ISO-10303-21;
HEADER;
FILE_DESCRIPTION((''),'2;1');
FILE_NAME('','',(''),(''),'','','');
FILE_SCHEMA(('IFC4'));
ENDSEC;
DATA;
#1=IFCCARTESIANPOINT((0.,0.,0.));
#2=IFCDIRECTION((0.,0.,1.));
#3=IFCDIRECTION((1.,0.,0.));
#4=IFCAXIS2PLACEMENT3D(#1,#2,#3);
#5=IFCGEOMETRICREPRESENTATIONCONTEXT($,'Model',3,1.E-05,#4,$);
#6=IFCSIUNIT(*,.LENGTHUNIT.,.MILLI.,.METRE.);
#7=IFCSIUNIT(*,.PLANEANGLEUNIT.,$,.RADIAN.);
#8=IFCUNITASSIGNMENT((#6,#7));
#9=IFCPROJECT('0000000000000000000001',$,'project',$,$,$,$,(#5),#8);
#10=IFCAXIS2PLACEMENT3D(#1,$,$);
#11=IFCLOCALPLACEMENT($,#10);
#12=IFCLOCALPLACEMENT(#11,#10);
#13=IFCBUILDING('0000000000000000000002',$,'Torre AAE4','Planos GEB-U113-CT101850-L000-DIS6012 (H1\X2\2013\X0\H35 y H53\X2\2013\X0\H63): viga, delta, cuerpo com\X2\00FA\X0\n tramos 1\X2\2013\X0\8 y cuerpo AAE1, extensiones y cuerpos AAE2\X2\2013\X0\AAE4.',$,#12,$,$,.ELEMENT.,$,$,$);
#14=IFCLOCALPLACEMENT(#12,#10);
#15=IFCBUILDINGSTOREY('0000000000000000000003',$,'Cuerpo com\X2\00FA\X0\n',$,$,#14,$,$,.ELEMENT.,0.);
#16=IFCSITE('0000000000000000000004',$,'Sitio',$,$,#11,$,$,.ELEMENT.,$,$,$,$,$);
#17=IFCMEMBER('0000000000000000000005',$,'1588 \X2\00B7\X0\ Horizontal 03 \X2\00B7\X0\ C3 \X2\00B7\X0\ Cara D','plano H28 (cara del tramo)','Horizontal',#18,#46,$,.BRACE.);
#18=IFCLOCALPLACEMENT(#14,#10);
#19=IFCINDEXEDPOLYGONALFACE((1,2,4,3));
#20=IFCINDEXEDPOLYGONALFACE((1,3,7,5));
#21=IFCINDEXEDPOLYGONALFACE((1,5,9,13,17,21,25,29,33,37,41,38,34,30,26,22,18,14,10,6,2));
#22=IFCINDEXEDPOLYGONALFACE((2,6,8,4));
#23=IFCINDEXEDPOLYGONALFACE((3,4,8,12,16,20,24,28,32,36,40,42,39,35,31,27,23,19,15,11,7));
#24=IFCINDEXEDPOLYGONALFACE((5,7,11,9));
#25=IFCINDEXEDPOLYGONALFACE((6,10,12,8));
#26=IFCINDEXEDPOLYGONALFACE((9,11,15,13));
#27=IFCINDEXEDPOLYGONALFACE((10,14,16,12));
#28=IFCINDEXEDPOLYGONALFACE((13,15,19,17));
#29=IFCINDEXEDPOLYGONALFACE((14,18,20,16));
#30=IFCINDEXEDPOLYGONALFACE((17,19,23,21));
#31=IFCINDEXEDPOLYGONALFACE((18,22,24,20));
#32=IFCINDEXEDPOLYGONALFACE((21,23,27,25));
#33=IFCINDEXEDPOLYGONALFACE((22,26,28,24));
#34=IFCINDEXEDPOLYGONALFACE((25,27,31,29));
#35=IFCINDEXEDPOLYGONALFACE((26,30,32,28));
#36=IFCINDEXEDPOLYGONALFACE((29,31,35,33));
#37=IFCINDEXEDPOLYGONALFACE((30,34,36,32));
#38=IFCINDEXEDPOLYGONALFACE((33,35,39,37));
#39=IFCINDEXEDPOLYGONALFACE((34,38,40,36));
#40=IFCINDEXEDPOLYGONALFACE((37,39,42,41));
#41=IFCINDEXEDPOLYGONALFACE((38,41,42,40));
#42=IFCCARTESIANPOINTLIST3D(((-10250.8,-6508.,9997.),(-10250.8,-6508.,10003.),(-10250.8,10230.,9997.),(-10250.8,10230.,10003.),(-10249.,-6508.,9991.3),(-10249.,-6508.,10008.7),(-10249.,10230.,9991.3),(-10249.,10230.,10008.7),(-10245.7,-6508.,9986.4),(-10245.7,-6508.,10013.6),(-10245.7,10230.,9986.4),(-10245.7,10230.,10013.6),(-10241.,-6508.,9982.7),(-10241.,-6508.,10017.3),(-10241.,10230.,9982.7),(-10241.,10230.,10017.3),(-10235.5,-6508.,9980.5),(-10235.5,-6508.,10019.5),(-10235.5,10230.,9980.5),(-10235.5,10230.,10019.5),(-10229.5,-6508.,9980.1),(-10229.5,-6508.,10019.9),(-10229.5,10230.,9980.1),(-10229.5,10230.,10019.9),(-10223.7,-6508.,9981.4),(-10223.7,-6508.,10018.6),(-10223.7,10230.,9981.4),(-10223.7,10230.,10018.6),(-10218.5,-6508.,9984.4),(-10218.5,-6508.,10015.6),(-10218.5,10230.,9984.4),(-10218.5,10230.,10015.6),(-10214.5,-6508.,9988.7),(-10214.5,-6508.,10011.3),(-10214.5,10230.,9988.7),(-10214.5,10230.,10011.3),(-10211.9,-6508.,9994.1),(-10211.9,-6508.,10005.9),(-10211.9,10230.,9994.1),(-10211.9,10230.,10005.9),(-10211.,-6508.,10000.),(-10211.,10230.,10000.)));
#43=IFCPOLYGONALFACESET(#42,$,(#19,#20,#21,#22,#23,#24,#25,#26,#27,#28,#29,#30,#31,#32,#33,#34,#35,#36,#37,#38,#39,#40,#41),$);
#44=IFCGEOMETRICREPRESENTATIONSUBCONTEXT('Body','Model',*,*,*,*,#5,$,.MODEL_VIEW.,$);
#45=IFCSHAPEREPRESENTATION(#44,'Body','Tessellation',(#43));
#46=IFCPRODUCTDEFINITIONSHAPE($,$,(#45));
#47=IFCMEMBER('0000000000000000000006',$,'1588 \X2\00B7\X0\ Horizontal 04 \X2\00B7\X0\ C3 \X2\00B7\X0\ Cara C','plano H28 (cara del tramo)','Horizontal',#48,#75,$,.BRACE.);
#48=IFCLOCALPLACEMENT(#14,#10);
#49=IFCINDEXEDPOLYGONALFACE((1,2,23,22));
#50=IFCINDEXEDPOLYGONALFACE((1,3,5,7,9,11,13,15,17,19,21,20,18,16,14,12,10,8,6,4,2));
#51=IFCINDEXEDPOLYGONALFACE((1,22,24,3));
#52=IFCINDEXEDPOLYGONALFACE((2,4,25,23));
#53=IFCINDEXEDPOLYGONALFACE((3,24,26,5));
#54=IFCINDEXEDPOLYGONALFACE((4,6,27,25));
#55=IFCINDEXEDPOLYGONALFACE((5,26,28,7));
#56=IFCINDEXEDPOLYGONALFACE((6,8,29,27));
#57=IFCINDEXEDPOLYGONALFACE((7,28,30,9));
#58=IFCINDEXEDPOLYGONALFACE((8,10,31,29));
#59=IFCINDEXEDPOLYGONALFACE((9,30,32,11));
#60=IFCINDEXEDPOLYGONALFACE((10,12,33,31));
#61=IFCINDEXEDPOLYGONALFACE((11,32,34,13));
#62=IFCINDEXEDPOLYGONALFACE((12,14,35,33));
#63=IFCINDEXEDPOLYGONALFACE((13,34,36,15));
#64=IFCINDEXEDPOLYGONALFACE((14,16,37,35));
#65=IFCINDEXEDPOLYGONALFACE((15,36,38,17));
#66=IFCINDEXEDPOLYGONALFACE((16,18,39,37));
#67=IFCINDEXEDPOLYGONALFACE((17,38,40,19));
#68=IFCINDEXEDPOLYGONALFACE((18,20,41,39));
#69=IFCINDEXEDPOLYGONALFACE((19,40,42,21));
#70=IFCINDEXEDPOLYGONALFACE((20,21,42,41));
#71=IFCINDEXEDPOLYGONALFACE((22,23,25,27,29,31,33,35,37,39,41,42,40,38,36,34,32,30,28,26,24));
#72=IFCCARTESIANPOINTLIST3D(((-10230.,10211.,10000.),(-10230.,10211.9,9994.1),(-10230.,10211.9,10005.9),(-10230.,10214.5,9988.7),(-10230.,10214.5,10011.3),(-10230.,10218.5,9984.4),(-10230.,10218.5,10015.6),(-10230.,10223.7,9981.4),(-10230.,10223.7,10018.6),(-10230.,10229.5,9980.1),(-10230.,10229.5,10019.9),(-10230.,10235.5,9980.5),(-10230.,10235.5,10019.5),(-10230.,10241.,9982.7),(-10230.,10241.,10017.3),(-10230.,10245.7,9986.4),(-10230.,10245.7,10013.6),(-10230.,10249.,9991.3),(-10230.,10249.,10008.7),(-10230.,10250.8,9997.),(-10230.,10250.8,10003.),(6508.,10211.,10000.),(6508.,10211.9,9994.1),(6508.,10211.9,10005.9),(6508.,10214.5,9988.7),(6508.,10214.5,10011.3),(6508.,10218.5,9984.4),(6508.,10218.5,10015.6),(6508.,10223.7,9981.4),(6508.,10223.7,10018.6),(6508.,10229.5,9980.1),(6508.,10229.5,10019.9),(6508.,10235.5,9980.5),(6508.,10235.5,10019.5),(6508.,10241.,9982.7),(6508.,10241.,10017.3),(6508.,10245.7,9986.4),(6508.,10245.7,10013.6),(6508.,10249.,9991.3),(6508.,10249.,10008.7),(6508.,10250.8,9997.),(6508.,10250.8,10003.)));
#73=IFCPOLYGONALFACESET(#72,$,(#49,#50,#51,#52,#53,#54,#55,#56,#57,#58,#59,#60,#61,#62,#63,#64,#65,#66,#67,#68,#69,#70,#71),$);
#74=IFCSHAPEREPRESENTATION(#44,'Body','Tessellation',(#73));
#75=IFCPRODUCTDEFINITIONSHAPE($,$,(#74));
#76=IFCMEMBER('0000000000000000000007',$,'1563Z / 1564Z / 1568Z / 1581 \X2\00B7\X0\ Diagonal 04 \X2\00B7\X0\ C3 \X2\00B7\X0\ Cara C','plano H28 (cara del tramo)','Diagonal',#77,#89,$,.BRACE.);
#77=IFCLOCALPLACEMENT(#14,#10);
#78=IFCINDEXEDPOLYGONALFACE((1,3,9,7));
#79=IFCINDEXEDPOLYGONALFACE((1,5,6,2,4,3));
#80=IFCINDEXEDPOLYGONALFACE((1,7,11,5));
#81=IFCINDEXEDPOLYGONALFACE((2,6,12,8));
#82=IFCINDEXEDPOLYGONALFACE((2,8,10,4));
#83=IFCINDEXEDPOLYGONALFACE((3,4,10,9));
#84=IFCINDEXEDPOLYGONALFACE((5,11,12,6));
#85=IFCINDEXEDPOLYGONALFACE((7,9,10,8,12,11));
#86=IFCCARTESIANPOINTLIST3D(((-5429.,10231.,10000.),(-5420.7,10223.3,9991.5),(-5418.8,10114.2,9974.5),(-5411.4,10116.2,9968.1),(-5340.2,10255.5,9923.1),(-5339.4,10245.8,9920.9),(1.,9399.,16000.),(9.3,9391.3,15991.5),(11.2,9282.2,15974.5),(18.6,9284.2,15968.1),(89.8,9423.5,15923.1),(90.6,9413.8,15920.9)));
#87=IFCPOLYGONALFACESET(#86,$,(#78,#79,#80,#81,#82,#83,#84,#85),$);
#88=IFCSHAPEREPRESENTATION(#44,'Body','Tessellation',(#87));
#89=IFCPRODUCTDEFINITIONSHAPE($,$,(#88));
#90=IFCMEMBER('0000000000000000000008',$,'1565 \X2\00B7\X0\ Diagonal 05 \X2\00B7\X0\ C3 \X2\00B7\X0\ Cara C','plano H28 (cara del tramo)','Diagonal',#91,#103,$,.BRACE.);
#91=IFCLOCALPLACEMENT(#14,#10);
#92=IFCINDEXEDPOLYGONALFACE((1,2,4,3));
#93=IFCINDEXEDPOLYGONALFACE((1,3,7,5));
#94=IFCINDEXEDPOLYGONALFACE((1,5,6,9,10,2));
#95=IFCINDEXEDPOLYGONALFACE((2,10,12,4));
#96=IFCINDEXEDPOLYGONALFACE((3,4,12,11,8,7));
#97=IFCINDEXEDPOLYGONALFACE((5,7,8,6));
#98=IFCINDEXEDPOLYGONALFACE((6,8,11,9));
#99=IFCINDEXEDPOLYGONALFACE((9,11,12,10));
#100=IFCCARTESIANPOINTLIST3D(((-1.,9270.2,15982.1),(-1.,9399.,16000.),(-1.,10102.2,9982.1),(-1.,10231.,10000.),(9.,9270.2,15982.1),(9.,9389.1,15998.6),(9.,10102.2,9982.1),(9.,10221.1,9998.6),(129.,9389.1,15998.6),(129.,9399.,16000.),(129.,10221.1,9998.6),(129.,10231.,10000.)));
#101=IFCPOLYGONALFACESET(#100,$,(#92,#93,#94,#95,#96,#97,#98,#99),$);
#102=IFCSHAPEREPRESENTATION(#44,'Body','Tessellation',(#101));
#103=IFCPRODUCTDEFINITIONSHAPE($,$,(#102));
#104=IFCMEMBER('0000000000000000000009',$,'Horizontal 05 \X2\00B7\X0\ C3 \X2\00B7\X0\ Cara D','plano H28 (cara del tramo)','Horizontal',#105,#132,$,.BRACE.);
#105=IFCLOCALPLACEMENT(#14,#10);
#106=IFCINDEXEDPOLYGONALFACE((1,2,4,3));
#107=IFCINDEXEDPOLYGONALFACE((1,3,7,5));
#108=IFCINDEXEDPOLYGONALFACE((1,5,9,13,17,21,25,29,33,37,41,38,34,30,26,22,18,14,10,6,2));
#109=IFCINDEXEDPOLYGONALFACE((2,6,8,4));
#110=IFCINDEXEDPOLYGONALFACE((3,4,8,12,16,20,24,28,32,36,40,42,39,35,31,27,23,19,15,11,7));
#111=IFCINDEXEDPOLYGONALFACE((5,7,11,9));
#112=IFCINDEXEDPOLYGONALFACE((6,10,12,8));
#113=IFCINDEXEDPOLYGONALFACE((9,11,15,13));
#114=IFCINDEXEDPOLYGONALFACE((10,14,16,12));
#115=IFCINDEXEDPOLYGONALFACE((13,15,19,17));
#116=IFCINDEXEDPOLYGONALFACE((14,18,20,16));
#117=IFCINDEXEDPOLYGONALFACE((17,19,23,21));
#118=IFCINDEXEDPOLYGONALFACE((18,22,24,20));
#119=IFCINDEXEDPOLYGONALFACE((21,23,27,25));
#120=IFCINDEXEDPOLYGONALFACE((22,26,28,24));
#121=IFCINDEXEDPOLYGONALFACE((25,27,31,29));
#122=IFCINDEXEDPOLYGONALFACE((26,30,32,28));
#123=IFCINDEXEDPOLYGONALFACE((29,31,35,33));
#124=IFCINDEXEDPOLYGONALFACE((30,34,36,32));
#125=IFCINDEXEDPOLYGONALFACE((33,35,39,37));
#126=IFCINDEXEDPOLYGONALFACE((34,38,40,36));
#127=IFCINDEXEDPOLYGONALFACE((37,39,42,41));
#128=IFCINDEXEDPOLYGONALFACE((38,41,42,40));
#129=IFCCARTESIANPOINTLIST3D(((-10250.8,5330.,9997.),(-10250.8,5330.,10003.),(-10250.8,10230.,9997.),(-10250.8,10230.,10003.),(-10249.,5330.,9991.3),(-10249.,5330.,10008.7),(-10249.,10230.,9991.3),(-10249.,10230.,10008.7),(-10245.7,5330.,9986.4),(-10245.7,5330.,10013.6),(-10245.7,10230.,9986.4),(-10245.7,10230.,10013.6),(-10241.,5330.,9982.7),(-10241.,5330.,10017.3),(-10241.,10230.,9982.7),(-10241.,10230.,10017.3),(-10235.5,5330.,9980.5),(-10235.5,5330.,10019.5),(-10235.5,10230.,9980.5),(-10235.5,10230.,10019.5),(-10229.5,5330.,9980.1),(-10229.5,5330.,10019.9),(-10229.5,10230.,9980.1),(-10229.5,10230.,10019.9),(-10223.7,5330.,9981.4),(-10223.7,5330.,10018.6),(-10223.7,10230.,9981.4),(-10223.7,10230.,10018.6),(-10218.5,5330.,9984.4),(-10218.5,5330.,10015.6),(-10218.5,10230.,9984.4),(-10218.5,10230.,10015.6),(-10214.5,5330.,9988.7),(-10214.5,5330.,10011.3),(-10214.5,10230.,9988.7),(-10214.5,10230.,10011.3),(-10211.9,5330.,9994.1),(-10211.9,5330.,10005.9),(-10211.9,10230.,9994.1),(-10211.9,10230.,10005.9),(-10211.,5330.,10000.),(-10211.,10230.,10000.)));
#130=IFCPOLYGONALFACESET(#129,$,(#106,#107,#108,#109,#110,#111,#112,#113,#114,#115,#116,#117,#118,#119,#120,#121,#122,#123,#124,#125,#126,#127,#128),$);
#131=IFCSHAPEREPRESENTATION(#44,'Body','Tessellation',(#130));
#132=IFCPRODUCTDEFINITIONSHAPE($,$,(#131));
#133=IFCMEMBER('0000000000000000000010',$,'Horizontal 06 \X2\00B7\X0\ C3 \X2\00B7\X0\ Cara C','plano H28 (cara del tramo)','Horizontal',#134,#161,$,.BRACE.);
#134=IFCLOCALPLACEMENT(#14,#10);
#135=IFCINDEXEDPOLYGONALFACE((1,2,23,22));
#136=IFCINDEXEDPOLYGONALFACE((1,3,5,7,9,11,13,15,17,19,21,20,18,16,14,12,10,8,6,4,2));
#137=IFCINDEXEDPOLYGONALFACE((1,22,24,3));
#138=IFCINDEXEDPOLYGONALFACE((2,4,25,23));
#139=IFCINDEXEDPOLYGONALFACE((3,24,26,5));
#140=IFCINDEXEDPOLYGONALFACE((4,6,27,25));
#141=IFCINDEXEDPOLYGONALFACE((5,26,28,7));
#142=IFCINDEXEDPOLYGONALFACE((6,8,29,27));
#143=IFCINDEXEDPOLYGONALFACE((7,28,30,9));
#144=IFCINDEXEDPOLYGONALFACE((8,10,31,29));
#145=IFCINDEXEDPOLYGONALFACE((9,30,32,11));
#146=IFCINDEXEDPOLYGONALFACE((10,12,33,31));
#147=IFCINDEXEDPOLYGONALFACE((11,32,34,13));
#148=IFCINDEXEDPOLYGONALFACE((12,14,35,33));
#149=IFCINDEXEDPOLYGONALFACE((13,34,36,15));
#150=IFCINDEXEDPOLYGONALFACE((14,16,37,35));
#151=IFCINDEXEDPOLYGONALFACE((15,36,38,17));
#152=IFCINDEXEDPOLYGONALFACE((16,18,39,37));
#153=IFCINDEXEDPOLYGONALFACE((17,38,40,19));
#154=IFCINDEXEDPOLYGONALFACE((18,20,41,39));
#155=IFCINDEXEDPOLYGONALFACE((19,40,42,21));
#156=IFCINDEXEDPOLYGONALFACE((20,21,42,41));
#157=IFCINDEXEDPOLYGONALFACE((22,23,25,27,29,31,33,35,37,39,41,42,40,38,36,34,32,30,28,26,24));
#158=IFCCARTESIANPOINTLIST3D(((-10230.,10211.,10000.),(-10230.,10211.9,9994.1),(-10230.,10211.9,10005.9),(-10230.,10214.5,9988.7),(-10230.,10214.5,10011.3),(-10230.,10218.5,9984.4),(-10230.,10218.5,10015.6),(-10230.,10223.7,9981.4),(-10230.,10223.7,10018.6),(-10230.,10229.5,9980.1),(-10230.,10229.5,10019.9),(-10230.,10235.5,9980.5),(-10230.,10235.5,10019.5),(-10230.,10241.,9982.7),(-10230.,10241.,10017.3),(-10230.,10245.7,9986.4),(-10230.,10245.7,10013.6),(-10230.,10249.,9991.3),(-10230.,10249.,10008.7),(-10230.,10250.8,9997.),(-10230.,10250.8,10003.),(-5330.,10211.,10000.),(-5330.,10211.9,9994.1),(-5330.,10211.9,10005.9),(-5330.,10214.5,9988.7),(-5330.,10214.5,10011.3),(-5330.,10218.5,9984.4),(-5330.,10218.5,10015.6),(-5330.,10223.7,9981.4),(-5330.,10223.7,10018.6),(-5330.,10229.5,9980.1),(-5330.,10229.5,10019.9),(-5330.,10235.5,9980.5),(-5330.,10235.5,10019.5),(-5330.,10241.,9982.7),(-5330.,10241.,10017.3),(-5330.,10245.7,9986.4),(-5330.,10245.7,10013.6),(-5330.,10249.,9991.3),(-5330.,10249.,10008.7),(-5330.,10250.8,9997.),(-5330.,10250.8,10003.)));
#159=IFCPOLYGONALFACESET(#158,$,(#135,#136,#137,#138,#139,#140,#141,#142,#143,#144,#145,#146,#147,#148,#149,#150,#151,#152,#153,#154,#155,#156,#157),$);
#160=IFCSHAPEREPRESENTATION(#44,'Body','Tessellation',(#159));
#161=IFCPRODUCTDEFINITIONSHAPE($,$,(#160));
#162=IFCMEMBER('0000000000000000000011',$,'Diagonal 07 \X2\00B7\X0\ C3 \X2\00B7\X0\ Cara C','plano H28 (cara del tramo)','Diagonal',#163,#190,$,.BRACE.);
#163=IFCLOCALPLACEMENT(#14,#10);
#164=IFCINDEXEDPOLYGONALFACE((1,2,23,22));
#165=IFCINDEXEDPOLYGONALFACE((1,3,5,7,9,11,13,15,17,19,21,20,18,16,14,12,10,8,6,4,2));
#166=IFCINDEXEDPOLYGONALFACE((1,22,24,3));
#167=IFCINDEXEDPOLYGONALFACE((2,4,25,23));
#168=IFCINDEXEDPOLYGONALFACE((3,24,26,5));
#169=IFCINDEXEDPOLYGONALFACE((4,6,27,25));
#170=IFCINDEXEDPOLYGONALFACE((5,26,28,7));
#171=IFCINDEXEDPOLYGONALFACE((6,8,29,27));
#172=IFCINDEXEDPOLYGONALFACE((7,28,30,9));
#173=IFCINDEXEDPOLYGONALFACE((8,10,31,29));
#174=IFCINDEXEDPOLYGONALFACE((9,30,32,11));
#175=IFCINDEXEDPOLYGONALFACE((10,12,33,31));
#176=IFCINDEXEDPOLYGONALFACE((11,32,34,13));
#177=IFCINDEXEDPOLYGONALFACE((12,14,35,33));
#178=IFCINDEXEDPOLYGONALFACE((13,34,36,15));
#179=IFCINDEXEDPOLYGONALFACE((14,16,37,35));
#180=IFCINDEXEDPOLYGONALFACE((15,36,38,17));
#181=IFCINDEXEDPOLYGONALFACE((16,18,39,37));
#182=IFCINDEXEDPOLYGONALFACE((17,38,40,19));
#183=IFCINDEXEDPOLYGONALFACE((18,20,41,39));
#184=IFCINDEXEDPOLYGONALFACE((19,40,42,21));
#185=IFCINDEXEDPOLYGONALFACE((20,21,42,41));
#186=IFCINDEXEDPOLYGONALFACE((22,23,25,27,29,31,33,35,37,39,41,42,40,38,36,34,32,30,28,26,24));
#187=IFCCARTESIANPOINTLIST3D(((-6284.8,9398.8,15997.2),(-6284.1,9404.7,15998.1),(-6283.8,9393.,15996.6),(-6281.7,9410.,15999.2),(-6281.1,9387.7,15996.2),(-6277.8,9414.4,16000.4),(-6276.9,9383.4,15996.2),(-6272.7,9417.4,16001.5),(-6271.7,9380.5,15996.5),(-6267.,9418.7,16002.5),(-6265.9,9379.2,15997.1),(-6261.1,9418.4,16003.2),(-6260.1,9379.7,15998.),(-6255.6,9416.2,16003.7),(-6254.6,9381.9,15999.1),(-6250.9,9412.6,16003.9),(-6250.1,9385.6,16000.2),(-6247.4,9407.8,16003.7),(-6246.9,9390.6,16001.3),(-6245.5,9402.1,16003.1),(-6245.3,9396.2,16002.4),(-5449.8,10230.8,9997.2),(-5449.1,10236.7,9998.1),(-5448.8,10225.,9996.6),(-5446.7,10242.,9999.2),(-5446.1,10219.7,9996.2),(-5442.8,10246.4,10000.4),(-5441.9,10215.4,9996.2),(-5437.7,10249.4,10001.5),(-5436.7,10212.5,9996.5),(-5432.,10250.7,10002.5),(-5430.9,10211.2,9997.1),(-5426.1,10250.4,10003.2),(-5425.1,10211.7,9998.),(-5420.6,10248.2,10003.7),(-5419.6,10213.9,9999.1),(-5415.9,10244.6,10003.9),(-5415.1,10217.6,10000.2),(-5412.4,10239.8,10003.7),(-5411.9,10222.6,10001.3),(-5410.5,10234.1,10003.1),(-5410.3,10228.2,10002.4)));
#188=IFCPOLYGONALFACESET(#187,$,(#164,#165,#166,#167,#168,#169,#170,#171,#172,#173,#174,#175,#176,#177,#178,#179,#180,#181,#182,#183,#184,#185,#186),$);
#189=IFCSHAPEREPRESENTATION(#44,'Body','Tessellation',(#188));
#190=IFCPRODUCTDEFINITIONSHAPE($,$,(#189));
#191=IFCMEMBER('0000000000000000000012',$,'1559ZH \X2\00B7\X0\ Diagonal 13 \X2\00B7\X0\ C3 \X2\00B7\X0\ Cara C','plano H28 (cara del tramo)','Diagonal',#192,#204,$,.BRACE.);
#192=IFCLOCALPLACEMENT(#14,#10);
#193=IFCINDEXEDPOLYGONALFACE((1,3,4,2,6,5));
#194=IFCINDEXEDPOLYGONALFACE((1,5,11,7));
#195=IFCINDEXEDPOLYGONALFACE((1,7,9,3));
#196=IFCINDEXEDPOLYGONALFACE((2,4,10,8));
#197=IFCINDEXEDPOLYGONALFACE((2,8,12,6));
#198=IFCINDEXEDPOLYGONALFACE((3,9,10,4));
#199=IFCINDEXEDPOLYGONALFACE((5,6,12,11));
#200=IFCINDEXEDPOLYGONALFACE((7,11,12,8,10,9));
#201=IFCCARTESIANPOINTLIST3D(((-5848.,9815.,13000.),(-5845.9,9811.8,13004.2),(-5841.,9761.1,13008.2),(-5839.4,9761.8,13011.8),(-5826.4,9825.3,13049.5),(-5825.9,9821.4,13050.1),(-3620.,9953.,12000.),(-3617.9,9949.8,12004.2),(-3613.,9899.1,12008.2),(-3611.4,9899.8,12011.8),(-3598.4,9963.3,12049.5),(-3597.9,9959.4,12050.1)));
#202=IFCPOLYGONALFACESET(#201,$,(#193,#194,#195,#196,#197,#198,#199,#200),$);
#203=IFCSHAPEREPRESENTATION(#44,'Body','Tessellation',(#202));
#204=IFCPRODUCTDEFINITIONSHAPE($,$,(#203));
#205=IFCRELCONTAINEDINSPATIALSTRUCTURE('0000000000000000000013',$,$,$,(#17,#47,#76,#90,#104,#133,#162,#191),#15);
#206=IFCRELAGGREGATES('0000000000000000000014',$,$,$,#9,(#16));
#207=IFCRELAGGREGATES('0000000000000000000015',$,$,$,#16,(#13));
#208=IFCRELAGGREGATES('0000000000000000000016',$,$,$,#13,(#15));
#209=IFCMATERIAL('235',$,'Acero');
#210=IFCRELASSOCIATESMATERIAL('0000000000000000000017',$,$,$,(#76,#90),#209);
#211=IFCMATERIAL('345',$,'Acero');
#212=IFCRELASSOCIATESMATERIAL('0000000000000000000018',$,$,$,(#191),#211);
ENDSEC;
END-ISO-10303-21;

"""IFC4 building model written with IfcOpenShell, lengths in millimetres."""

from ifc_helpers import new_model, si_unit, frame, frame_2d, origin, origin_with_axes, place, context, subcontext, project, spatial, circle, l_section, extrude, material, element, save


model = new_model("IFC4")

# Units and contexts
model_context = context("Model", 3, precision=1e-05, world=origin_with_axes())
body_context = subcontext(model_context, "Body", "Model", "MODEL_VIEW")
ifc_project = project(units=[si_unit("LENGTHUNIT", "METRE", prefix="MILLI"), si_unit("PLANEANGLEUNIT", "RADIAN")], contexts=[model_context])

# Site, building, storey
site_placement = place(None, origin())
site = spatial("IfcSite", under=ifc_project, at=site_placement, Name="Sitio", CompositionType="ELEMENT")
building_placement = place(site_placement, origin())
building = spatial("IfcBuilding", under=site, at=building_placement, Name="Torre AAE4", Description="Planos GEB-U113-CT101850-L000-DIS6012 (H1–H35 y H53–H63): viga, delta, cuerpo común tramos 1–8 y cuerpo AAE1, extensiones y cuerpos AAE2–AAE4.", CompositionType="ELEMENT")
storey_placement = place(building_placement, origin())
storey = spatial("IfcBuildingStorey", under=building, at=storey_placement, Name="Cuerpo común", CompositionType="ELEMENT", Elevation=0.0)

# Members
for number, where, z_axis, x_axis, name in (
    (1, (-10231.0, 10230.0, 10000.0), (0.0, -1.0, 0.0), (1.0, 0.0, 0.0), "1588 · Horizontal 03 · C3 · Cara D"),
    (2, (-10230.0, 10231.0, 10000.0), (1.0, 0.0, 0.0), (0.0, -1.0, 0.0), "1588 · Horizontal 04 · C3 · Cara C"),
):
    element("IfcMember", number, at=place(storey_placement, frame(where, z_axis=z_axis, x_axis=x_axis)), inside=storey, Name=name, Description="plano H28 (cara del tramo)", ObjectType="Horizontal", PredefinedType="BRACE", context=body_context, shape_type="SweptSolid", body=[
        extrude(circle(Radius=20.0), None, (0.0, 0.0, 1.0), 16738.0),
    ])
ifc_material_1 = material(Name="235", Category="Acero")
member_1_placement = place(storey_placement, frame((-5429.0, 10231.0, 10000.0), z_axis=(0.667492, -0.102275, 0.73756), x_axis=(0.085296, -0.9735, -0.212185)))
element("IfcMember", 3, at=member_1_placement, inside=storey, material=ifc_material_1, Name="1563Z / 1564Z / 1568Z / 1581 · Diagonal 04 · C3 · Cara C", Description="plano H28 (cara del tramo)", ObjectType="Diagonal", PredefinedType="BRACE", context=body_context, shape_type="SweptSolid", body=[
    extrude(l_section(Depth=120.0, Width=120.0, Thickness=10.0, at=frame_2d((60.0, 60.0))), None, (0.0, 0.0, 1.0), 8134.9),
])
member_2_placement = place(storey_placement, frame((-1.0, 10231.0, 10000.0), z_axis=(0.0, -0.137352, 0.990522), x_axis=(0.000103, -0.990522, -0.137352)))
element("IfcMember", 4, at=member_2_placement, inside=storey, material=ifc_material_1, Name="1565 · Diagonal 05 · C3 · Cara C", Description="plano H28 (cara del tramo)", ObjectType="Diagonal", PredefinedType="BRACE", context=body_context, shape_type="SweptSolid", body=[
    extrude(l_section(Depth=130.0, Width=130.0, Thickness=10.0, at=frame_2d((65.0, 65.0))), None, (0.0, 0.0, 1.0), 6057.4),
])
for number, where, z_axis, x_axis, name in (
    (5, (-10231.0, 10230.0, 10000.0), (0.0, -1.0, 0.0), (1.0, 0.0, 0.0), "Horizontal 05 · C3 · Cara D"),
    (6, (-10230.0, 10231.0, 10000.0), (1.0, 0.0, 0.0), (0.0, -1.0, 0.0), "Horizontal 06 · C3 · Cara C"),
):
    element("IfcMember", number, at=place(storey_placement, frame(where, z_axis=z_axis, x_axis=x_axis)), inside=storey, Name=name, Description="plano H28 (cara del tramo)", ObjectType="Horizontal", PredefinedType="BRACE", context=body_context, shape_type="SweptSolid", body=[
        extrude(circle(Radius=20.0), None, (0.0, 0.0, 1.0), 4900.0),
    ])
member_3_placement = place(storey_placement, frame((-5430.0, 10231.0, 10000.0), z_axis=(-0.136556, -0.136066, 0.981243), x_axis=(0.518814, -0.85364, -0.04617)))
element("IfcMember", 7, at=member_3_placement, inside=storey, Name="Diagonal 07 · C3 · Cara C", Description="plano H28 (cara del tramo)", ObjectType="Diagonal", PredefinedType="BRACE", context=body_context, shape_type="SweptSolid", body=[
    extrude(circle(Radius=20.0), None, (0.0, 0.0, 1.0), 6114.7),
])
ifc_material_2 = material(Name="345", Category="Acero")
member_4_placement = place(storey_placement, frame((-3620.0, 9953.0, 12000.0), z_axis=(-0.910866, -0.056418, 0.408827), x_axis=(0.127645, -0.980552, 0.149077)))
element("IfcMember", 8, at=member_4_placement, inside=storey, material=ifc_material_2, Name="1559ZH · Diagonal 13 · C3 · Cara C", Description="plano H28 (cara del tramo)", ObjectType="Diagonal", PredefinedType="BRACE", context=body_context, shape_type="SweptSolid", body=[
    extrude(l_section(Depth=55.0, Width=55.0, Thickness=4.0, at=frame_2d((27.5, 27.5))), None, (0.0, 0.0, 1.0), 2446.0),
])

save(model, "model.ifc")
